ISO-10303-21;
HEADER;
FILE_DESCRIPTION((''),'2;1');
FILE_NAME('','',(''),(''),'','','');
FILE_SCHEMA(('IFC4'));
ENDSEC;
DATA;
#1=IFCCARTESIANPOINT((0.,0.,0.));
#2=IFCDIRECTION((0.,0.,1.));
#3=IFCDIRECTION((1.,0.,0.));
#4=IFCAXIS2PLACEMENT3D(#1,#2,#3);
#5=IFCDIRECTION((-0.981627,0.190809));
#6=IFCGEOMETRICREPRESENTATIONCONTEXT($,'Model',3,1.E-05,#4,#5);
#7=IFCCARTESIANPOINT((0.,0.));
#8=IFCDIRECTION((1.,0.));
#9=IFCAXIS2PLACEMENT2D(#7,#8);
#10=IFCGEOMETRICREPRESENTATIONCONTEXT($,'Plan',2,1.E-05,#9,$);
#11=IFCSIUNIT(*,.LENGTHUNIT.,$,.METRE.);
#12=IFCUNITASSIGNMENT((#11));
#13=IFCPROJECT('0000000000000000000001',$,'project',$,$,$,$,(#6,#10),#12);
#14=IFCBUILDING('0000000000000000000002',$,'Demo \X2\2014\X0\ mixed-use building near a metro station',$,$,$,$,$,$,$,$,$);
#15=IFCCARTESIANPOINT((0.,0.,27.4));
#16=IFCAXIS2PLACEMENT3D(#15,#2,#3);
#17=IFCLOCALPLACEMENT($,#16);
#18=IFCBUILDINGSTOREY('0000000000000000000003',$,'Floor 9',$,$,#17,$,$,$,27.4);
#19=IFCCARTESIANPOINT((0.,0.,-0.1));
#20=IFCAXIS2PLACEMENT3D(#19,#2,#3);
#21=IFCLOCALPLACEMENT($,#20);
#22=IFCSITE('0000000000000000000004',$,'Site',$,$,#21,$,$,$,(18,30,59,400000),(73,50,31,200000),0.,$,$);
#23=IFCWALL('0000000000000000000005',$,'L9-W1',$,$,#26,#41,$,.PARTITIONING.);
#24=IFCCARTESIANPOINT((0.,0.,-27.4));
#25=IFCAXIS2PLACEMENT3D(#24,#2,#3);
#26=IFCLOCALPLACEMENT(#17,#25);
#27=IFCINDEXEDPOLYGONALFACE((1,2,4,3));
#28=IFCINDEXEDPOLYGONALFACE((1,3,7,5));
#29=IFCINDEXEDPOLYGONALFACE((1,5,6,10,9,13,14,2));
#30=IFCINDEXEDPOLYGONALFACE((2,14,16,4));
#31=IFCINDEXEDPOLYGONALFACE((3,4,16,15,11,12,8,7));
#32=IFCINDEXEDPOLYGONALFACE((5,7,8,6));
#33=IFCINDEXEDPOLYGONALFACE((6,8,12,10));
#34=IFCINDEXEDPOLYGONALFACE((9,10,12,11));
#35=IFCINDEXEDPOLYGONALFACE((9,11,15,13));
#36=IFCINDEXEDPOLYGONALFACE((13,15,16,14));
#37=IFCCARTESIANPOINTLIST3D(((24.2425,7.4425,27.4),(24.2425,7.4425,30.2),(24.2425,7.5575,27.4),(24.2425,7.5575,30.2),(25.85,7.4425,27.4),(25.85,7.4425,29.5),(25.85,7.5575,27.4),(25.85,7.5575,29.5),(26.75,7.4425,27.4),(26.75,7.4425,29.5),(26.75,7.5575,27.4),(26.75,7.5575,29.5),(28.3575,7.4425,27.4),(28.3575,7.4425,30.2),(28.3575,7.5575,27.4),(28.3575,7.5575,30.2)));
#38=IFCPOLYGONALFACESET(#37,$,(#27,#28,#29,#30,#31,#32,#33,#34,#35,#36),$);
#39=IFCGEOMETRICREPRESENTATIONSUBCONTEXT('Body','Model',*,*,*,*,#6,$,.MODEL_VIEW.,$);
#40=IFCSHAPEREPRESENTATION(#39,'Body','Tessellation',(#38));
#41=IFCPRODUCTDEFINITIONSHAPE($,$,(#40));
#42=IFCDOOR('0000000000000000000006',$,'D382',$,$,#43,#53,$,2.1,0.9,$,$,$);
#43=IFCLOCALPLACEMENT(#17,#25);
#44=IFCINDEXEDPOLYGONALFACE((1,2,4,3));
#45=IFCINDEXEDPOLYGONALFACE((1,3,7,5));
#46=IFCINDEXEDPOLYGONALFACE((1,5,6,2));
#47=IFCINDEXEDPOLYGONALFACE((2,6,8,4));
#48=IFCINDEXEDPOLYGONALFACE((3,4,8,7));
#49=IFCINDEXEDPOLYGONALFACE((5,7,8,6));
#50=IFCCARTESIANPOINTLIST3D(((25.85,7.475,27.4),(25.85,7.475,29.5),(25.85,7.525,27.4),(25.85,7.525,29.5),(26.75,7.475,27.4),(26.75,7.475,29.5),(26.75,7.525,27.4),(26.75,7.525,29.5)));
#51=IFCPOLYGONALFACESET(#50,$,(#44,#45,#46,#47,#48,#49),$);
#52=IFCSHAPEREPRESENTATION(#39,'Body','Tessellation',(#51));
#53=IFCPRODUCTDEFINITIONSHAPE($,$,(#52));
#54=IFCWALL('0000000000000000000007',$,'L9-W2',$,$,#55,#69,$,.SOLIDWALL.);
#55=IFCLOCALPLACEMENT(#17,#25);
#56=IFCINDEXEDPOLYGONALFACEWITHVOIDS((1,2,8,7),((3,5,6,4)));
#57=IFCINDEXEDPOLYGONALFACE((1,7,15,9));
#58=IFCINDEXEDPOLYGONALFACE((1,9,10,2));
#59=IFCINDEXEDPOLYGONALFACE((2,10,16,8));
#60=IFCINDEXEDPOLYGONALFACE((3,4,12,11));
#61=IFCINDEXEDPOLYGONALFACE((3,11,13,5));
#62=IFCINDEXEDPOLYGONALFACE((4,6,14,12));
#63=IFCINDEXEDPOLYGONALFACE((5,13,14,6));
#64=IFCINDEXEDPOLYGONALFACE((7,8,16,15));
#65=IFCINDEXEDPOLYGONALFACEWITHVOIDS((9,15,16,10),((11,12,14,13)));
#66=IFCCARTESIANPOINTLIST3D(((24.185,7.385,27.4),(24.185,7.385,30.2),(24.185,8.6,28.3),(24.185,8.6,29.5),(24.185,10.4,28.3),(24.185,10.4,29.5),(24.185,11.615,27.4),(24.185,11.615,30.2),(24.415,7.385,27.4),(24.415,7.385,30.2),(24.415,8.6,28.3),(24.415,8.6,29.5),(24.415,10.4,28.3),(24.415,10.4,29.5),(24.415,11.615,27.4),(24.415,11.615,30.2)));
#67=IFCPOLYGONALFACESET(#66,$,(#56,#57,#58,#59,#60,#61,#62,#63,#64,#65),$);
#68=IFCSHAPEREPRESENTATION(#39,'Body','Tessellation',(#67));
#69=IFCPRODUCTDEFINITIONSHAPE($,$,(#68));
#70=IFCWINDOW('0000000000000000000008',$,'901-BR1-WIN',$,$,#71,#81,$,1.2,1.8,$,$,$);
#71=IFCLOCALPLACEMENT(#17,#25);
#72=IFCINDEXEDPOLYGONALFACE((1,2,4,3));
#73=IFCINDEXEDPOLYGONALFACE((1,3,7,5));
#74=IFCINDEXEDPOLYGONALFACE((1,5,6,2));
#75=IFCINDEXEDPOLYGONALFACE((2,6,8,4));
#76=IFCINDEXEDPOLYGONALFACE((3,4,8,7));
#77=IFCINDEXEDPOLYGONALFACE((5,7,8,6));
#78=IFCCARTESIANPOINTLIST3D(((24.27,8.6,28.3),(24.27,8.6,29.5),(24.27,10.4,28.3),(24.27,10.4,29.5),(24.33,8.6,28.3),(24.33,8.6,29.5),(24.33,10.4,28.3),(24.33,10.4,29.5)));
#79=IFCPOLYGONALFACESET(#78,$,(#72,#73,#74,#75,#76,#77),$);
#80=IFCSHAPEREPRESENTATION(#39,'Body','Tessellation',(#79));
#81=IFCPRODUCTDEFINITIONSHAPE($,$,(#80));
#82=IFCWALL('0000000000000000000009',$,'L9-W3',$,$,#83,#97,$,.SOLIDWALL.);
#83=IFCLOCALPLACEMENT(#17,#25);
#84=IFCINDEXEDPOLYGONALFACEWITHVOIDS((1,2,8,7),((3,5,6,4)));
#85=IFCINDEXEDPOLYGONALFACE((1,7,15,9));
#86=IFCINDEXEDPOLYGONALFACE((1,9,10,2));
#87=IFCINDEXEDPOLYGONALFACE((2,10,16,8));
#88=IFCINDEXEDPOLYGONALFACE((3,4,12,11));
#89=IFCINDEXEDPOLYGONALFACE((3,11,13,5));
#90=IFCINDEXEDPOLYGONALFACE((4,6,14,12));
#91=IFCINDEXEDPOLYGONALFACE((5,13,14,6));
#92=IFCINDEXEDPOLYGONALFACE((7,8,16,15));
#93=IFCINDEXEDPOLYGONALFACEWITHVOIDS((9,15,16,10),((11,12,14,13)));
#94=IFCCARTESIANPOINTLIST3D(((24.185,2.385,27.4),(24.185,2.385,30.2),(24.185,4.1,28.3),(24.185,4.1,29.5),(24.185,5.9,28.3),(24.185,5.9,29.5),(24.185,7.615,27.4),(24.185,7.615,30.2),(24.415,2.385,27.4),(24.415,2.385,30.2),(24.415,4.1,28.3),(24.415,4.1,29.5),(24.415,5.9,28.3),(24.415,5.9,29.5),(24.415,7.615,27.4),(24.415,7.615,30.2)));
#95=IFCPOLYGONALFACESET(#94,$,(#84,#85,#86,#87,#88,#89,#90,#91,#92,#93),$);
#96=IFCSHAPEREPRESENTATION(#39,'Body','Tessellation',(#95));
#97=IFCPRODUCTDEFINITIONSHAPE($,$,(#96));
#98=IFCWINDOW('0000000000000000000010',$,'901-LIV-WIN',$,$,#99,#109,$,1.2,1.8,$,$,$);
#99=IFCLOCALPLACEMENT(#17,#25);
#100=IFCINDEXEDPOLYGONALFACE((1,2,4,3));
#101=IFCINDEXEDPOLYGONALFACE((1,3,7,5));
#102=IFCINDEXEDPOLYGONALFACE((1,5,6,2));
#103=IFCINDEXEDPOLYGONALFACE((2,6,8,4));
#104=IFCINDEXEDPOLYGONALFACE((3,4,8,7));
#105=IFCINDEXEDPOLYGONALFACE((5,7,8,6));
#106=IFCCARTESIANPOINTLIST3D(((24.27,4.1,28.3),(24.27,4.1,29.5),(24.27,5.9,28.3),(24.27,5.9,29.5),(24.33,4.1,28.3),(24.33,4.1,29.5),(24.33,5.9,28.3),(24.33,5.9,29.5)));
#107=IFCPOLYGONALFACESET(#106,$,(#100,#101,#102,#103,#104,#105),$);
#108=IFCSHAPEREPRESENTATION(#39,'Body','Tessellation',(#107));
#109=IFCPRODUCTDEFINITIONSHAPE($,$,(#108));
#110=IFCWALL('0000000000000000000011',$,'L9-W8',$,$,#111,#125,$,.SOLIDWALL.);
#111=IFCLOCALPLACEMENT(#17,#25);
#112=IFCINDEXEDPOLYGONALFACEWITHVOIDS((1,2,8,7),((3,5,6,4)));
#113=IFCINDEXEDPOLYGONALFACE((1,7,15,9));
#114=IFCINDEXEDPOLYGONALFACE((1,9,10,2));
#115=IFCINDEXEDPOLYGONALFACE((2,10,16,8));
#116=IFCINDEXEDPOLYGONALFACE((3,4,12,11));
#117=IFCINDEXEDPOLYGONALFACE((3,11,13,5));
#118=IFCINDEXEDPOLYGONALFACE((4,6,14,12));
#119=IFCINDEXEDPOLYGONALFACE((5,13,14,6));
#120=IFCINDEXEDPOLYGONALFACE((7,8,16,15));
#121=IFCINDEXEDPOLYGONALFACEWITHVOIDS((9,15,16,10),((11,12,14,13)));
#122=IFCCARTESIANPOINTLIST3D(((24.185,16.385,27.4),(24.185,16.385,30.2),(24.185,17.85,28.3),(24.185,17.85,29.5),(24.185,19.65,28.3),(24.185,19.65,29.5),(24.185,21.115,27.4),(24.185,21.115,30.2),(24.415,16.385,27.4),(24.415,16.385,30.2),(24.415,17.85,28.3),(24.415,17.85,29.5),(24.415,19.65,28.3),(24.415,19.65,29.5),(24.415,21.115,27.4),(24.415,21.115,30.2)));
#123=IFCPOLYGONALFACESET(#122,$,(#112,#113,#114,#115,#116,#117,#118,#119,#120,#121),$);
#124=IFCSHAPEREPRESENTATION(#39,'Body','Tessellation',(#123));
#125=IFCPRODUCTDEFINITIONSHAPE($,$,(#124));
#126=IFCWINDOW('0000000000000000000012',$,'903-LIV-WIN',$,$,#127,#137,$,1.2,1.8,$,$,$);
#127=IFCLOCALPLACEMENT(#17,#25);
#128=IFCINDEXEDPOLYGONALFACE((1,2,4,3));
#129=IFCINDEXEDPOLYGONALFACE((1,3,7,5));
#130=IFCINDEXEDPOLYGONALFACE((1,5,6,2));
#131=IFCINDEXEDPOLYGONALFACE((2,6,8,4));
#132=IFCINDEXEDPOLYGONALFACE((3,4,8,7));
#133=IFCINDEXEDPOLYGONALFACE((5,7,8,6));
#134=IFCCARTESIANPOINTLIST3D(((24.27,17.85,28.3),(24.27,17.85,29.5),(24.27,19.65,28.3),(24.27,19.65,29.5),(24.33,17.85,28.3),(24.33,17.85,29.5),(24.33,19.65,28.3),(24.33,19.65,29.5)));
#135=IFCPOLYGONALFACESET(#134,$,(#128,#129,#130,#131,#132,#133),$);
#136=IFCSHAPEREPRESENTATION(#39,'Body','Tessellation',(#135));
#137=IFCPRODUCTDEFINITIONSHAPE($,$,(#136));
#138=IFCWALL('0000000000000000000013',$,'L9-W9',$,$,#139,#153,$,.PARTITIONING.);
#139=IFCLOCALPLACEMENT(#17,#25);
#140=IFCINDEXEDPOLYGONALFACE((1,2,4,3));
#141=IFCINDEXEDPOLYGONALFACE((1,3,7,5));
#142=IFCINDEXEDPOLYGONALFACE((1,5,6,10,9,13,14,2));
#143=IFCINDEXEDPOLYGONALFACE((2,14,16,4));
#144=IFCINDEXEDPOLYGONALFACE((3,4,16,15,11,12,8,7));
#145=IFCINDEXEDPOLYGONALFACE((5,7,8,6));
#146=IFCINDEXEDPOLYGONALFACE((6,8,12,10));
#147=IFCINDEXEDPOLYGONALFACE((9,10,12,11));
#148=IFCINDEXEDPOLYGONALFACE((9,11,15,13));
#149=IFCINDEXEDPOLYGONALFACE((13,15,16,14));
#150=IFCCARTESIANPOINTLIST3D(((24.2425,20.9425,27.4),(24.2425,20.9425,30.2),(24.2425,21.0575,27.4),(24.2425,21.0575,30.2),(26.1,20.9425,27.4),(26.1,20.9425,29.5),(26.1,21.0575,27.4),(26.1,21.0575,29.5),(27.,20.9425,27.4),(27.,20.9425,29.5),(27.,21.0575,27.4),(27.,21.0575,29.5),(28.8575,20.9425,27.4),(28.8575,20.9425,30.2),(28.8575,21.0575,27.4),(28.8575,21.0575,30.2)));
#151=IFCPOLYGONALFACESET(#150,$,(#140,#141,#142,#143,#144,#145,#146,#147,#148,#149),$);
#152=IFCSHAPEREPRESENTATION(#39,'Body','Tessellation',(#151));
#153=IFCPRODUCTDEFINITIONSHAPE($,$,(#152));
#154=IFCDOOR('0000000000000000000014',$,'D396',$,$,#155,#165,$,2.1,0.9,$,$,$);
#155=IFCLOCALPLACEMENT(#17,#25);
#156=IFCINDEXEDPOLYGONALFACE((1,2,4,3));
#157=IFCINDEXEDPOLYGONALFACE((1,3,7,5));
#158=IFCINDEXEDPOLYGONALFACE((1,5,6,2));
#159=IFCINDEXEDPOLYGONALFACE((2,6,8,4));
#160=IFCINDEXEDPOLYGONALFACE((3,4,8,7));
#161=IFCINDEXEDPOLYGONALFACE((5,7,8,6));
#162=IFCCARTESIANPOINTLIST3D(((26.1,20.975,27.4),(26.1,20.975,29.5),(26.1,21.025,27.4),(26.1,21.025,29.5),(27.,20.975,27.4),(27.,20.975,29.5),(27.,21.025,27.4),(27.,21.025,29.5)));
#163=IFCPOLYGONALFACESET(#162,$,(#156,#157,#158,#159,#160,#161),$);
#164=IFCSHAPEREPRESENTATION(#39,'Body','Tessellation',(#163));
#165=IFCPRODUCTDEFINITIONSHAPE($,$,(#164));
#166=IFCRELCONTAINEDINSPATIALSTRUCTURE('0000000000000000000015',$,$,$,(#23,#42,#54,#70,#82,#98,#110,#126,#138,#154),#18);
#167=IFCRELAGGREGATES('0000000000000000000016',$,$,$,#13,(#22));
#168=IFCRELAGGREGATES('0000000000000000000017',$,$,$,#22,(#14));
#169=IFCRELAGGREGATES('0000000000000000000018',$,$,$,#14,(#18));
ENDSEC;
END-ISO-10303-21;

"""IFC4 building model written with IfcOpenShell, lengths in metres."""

from ifc_helpers import new_model, si_unit, direction, frame, origin_with_axes, origin_2d_with_axis, place, context, subcontext, project, spatial, line, indexed_curve, outline, extrude, element, fill, save


model = new_model("IFC4")

# Units and contexts
model_context = context("Model", 3, precision=1e-05, world=origin_with_axes(), true_north=direction((-0.981627, 0.190809)))
plan_context = context("Plan", 2, precision=1e-05, world=origin_2d_with_axis())
body_context = subcontext(model_context, "Body", "Model", "MODEL_VIEW")
ifc_project = project(units=[si_unit("LENGTHUNIT", "METRE")], contexts=[model_context, plan_context])

# Site, building, storey
site_placement = place(None, frame((0.0, 0.0, -0.1), z_axis=(0.0, 0.0, 1.0), x_axis=(1.0, 0.0, 0.0)))
site = spatial("IfcSite", under=ifc_project, at=site_placement, Name="Site", RefLatitude=(18, 30, 59, 400000), RefLongitude=(73, 50, 31, 200000), RefElevation=0.0)
building = spatial("IfcBuilding", under=site, Name="Demo — mixed-use building near a metro station")
storey_placement = place(None, frame((0.0, 0.0, 27.4), z_axis=(0.0, 0.0, 1.0), x_axis=(1.0, 0.0, 0.0)))
storey = spatial("IfcBuildingStorey", under=building, at=storey_placement, Name="Floor 9", Elevation=27.4)

# Wall, opening, door
wall_1_placement = place(storey_placement, frame((0.0, 0.0, -27.4), z_axis=(0.0, 0.0, 1.0), x_axis=(1.0, 0.0, 0.0)))
wall_1 = element("IfcWall", 1, at=wall_1_placement, inside=storey, Name="L9-W1", PredefinedType="PARTITIONING", context=body_context, shape_type="SweptSolid", body=[
    extrude(outline(indexed_curve([(28.3575, 7.4425), (24.2425, 7.4425), (24.2425, 7.5575), (28.3575, 7.5575)], segments=[line(1, 2, 3, 4, 1)])), frame((0.0, 0.0, 27.4), z_axis=(0.0, 0.0, 1.0), x_axis=(1.0, 0.0, 0.0)), (0.0, 0.0, 1.0), 2.8),
])
opening_1_placement = place(wall_1_placement, origin_with_axes())
opening_1 = element("IfcOpeningElement", 2, at=opening_1_placement, cuts=wall_1, context=body_context, shape_type="SweptSolid", body=[
    extrude(outline(indexed_curve([(26.75, 7.3925), (25.85, 7.3925), (25.85, 7.6075), (26.75, 7.6075)], segments=[line(1, 2, 3, 4, 1)])), frame((0.0, 0.0, 27.4), z_axis=(0.0, 0.0, 1.0), x_axis=(1.0, 0.0, 0.0)), (0.0, 0.0, 1.0), 2.1),
])
door_1_placement = place(storey_placement, frame((0.0, 0.0, -27.4), z_axis=(0.0, 0.0, 1.0), x_axis=(1.0, 0.0, 0.0)))
door_1 = element("IfcDoor", 3, at=door_1_placement, inside=storey, Name="D382", OverallHeight=2.1, OverallWidth=0.9, context=body_context, shape_type="SweptSolid", body=[
    extrude(outline(indexed_curve([(26.75, 7.475), (25.85, 7.475), (25.85, 7.525), (26.75, 7.525)], segments=[line(1, 2, 3, 4, 1)])), frame((0.0, 0.0, 27.4), z_axis=(0.0, 0.0, 1.0), x_axis=(1.0, 0.0, 0.0)), (0.0, 0.0, 1.0), 2.1),
])
fill(opening_1, door_1)

# Walls, openings, windows
wall_2_placement = place(storey_placement, frame((0.0, 0.0, -27.4), z_axis=(0.0, 0.0, 1.0), x_axis=(1.0, 0.0, 0.0)))
wall_2 = element("IfcWall", 4, at=wall_2_placement, inside=storey, Name="L9-W2", PredefinedType="SOLIDWALL", context=body_context, shape_type="SweptSolid", body=[
    extrude(outline(indexed_curve([(24.415, 11.615), (24.415, 7.385), (24.185, 7.385), (24.185, 11.615)], segments=[line(1, 2, 3, 4, 1)])), frame((0.0, 0.0, 27.4), z_axis=(0.0, 0.0, 1.0), x_axis=(1.0, 0.0, 0.0)), (0.0, 0.0, 1.0), 2.8),
])
opening_2_placement = place(wall_2_placement, origin_with_axes())
opening_2 = element("IfcOpeningElement", 5, at=opening_2_placement, cuts=wall_2, context=body_context, shape_type="SweptSolid", body=[
    extrude(outline(indexed_curve([(24.465, 10.4), (24.465, 8.6), (24.135, 8.6), (24.135, 10.4)], segments=[line(1, 2, 3, 4, 1)])), frame((0.0, 0.0, 28.3), z_axis=(0.0, 0.0, 1.0), x_axis=(1.0, 0.0, 0.0)), (0.0, 0.0, 1.0), 1.2),
])
window_1_placement = place(storey_placement, frame((0.0, 0.0, -27.4), z_axis=(0.0, 0.0, 1.0), x_axis=(1.0, 0.0, 0.0)))
window_1 = element("IfcWindow", 6, at=window_1_placement, inside=storey, Name="901-BR1-WIN", OverallHeight=1.2, OverallWidth=1.8, context=body_context, shape_type="SweptSolid", body=[
    extrude(outline(indexed_curve([(24.33, 10.4), (24.33, 8.6), (24.27, 8.6), (24.27, 10.4)], segments=[line(1, 2, 3, 4, 1)])), frame((0.0, 0.0, 28.3), z_axis=(0.0, 0.0, 1.0), x_axis=(1.0, 0.0, 0.0)), (0.0, 0.0, 1.0), 1.2),
])
fill(opening_2, window_1)
wall_3_placement = place(storey_placement, frame((0.0, 0.0, -27.4), z_axis=(0.0, 0.0, 1.0), x_axis=(1.0, 0.0, 0.0)))
wall_3 = element("IfcWall", 7, at=wall_3_placement, inside=storey, Name="L9-W3", PredefinedType="SOLIDWALL", context=body_context, shape_type="SweptSolid", body=[
    extrude(outline(indexed_curve([(24.415, 7.615), (24.415, 2.385), (24.185, 2.385), (24.185, 7.615)], segments=[line(1, 2, 3, 4, 1)])), frame((0.0, 0.0, 27.4), z_axis=(0.0, 0.0, 1.0), x_axis=(1.0, 0.0, 0.0)), (0.0, 0.0, 1.0), 2.8),
])
opening_3_placement = place(wall_3_placement, origin_with_axes())
opening_3 = element("IfcOpeningElement", 8, at=opening_3_placement, cuts=wall_3, context=body_context, shape_type="SweptSolid", body=[
    extrude(outline(indexed_curve([(24.465, 5.9), (24.465, 4.1), (24.135, 4.1), (24.135, 5.9)], segments=[line(1, 2, 3, 4, 1)])), frame((0.0, 0.0, 28.3), z_axis=(0.0, 0.0, 1.0), x_axis=(1.0, 0.0, 0.0)), (0.0, 0.0, 1.0), 1.2),
])
window_2_placement = place(storey_placement, frame((0.0, 0.0, -27.4), z_axis=(0.0, 0.0, 1.0), x_axis=(1.0, 0.0, 0.0)))
window_2 = element("IfcWindow", 9, at=window_2_placement, inside=storey, Name="901-LIV-WIN", OverallHeight=1.2, OverallWidth=1.8, context=body_context, shape_type="SweptSolid", body=[
    extrude(outline(indexed_curve([(24.33, 5.9), (24.33, 4.1), (24.27, 4.1), (24.27, 5.9)], segments=[line(1, 2, 3, 4, 1)])), frame((0.0, 0.0, 28.3), z_axis=(0.0, 0.0, 1.0), x_axis=(1.0, 0.0, 0.0)), (0.0, 0.0, 1.0), 1.2),
])
fill(opening_3, window_2)

# Wall, opening, window
wall_4_placement = place(storey_placement, frame((0.0, 0.0, -27.4), z_axis=(0.0, 0.0, 1.0), x_axis=(1.0, 0.0, 0.0)))
wall_4 = element("IfcWall", 10, at=wall_4_placement, inside=storey, Name="L9-W8", PredefinedType="SOLIDWALL", context=body_context, shape_type="SweptSolid", body=[
    extrude(outline(indexed_curve([(24.415, 21.115), (24.415, 16.385), (24.185, 16.385), (24.185, 21.115)], segments=[line(1, 2, 3, 4, 1)])), frame((0.0, 0.0, 27.4), z_axis=(0.0, 0.0, 1.0), x_axis=(1.0, 0.0, 0.0)), (0.0, 0.0, 1.0), 2.8),
])
opening_4_placement = place(wall_4_placement, origin_with_axes())
opening_4 = element("IfcOpeningElement", 11, at=opening_4_placement, cuts=wall_4, context=body_context, shape_type="SweptSolid", body=[
    extrude(outline(indexed_curve([(24.465, 19.65), (24.465, 17.85), (24.135, 17.85), (24.135, 19.65)], segments=[line(1, 2, 3, 4, 1)])), frame((0.0, 0.0, 28.3), z_axis=(0.0, 0.0, 1.0), x_axis=(1.0, 0.0, 0.0)), (0.0, 0.0, 1.0), 1.2),
])
window_3_placement = place(storey_placement, frame((0.0, 0.0, -27.4), z_axis=(0.0, 0.0, 1.0), x_axis=(1.0, 0.0, 0.0)))
window_3 = element("IfcWindow", 12, at=window_3_placement, inside=storey, Name="903-LIV-WIN", OverallHeight=1.2, OverallWidth=1.8, context=body_context, shape_type="SweptSolid", body=[
    extrude(outline(indexed_curve([(24.33, 19.65), (24.33, 17.85), (24.27, 17.85), (24.27, 19.65)], segments=[line(1, 2, 3, 4, 1)])), frame((0.0, 0.0, 28.3), z_axis=(0.0, 0.0, 1.0), x_axis=(1.0, 0.0, 0.0)), (0.0, 0.0, 1.0), 1.2),
])
fill(opening_4, window_3)

# Wall, opening, door
wall_5_placement = place(storey_placement, frame((0.0, 0.0, -27.4), z_axis=(0.0, 0.0, 1.0), x_axis=(1.0, 0.0, 0.0)))
wall_5 = element("IfcWall", 13, at=wall_5_placement, inside=storey, Name="L9-W9", PredefinedType="PARTITIONING", context=body_context, shape_type="SweptSolid", body=[
    extrude(outline(indexed_curve([(28.8575, 20.9425), (24.2425, 20.9425), (24.2425, 21.0575), (28.8575, 21.0575)], segments=[line(1, 2, 3, 4, 1)])), frame((0.0, 0.0, 27.4), z_axis=(0.0, 0.0, 1.0), x_axis=(1.0, 0.0, 0.0)), (0.0, 0.0, 1.0), 2.8),
])
opening_5_placement = place(wall_5_placement, origin_with_axes())
opening_5 = element("IfcOpeningElement", 14, at=opening_5_placement, cuts=wall_5, context=body_context, shape_type="SweptSolid", body=[
    extrude(outline(indexed_curve([(27.0, 20.8925), (26.1, 20.8925), (26.1, 21.1075), (27.0, 21.1075)], segments=[line(1, 2, 3, 4, 1)])), frame((0.0, 0.0, 27.4), z_axis=(0.0, 0.0, 1.0), x_axis=(1.0, 0.0, 0.0)), (0.0, 0.0, 1.0), 2.1),
])
door_2_placement = place(storey_placement, frame((0.0, 0.0, -27.4), z_axis=(0.0, 0.0, 1.0), x_axis=(1.0, 0.0, 0.0)))
door_2 = element("IfcDoor", 15, at=door_2_placement, inside=storey, Name="D396", OverallHeight=2.1, OverallWidth=0.9, context=body_context, shape_type="SweptSolid", body=[
    extrude(outline(indexed_curve([(27.0, 20.975), (26.1, 20.975), (26.1, 21.025), (27.0, 21.025)], segments=[line(1, 2, 3, 4, 1)])), frame((0.0, 0.0, 27.4), z_axis=(0.0, 0.0, 1.0), x_axis=(1.0, 0.0, 0.0)), (0.0, 0.0, 1.0), 2.1),
])
fill(opening_5, door_2)

save(model, "model.ifc")
